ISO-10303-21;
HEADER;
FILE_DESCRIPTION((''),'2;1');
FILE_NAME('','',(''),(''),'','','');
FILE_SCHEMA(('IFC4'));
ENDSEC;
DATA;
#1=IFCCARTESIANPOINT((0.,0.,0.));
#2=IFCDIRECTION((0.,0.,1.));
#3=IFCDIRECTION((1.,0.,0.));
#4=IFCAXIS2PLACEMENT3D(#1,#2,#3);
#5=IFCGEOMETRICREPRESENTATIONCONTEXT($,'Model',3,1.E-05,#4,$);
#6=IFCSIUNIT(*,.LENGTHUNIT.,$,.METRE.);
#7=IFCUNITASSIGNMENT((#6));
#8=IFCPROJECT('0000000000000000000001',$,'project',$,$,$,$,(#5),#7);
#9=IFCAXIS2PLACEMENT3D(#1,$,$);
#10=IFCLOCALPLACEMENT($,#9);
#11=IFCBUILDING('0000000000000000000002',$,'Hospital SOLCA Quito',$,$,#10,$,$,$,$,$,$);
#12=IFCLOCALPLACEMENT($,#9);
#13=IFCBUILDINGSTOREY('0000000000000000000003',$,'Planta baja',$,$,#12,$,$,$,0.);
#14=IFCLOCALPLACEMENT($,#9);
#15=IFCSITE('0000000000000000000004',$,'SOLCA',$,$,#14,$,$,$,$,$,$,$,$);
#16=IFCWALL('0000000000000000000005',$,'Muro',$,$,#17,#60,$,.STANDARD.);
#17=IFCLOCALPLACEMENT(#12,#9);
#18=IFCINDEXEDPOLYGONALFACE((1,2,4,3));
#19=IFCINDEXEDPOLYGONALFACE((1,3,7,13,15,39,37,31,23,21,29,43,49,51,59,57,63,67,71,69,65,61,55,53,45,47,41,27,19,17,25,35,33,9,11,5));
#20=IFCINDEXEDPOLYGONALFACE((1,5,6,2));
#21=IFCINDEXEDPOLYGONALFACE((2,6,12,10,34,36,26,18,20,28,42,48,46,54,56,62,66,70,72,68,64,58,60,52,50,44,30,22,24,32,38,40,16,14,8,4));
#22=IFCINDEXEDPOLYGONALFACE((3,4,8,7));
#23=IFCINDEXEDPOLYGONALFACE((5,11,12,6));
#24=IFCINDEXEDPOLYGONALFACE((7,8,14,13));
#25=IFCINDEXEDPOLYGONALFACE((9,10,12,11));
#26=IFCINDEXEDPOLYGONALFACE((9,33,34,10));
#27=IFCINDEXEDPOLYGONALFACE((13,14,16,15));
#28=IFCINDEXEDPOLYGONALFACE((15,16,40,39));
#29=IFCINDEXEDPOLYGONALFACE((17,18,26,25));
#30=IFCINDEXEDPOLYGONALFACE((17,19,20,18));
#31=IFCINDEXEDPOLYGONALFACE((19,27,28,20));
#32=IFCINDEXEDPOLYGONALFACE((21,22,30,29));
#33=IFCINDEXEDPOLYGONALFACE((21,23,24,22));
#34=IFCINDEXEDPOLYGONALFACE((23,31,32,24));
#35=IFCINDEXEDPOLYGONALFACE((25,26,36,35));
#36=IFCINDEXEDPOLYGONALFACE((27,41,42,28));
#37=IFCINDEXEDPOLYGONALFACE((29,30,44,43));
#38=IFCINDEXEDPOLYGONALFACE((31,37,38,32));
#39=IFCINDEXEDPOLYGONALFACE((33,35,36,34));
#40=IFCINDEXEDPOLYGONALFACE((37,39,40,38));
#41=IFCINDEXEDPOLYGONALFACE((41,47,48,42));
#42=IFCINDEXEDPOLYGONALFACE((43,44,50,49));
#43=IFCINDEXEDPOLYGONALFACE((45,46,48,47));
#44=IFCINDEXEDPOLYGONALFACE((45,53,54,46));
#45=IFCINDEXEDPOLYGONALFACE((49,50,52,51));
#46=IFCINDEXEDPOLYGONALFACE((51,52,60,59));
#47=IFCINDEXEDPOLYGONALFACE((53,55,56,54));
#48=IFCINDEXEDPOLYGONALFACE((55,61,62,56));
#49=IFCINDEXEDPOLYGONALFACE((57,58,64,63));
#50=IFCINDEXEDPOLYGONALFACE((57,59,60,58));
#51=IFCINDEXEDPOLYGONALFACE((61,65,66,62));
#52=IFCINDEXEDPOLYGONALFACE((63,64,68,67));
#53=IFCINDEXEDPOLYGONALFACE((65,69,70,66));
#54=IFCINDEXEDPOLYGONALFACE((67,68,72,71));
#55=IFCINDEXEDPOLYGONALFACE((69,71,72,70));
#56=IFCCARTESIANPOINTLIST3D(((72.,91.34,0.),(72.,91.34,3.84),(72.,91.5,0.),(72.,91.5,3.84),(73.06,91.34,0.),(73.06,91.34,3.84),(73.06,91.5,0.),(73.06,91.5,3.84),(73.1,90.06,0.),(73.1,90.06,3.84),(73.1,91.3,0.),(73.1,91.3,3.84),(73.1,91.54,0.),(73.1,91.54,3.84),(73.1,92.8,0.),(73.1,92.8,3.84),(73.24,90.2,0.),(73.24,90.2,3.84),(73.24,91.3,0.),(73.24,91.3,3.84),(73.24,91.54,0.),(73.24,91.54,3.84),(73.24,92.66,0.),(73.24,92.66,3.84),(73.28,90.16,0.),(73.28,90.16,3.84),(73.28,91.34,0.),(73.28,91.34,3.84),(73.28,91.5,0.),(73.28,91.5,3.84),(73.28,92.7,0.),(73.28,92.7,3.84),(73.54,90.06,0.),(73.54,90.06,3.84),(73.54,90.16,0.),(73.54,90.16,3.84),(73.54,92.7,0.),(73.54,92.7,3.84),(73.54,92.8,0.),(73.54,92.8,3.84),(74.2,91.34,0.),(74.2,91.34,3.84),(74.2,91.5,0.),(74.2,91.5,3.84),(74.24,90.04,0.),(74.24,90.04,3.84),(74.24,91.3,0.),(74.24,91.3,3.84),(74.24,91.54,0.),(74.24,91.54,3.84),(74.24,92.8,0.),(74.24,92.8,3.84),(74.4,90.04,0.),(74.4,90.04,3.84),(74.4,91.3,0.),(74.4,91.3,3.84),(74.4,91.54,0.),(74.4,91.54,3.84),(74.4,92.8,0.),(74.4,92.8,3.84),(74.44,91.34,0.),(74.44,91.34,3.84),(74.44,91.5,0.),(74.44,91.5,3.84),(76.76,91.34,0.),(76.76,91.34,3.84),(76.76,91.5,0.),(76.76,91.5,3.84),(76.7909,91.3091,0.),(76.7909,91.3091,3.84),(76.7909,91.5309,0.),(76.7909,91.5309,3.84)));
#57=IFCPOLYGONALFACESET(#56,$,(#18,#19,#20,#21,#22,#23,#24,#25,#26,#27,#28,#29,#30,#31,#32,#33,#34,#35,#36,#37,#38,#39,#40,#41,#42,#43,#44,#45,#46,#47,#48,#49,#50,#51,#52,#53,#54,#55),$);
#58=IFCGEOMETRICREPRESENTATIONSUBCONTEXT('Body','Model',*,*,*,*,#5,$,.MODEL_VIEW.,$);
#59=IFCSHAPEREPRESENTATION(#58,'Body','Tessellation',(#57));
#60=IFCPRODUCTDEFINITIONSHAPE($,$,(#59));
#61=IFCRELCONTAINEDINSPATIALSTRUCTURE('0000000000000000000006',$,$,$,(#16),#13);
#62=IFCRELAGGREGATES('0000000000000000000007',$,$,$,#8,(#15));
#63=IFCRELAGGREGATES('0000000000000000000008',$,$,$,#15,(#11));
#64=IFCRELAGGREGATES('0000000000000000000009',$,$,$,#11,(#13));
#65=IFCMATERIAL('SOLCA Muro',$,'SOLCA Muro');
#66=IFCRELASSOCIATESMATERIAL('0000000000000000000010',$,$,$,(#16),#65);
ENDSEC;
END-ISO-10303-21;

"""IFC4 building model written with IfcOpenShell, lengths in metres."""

from ifc_helpers import new_model, si_unit, origin, origin_with_axes, place, context, subcontext, project, spatial, polyline, outline, extrude, material, element, save


model = new_model("IFC4")

# Units and contexts
model_context = context("Model", 3, precision=1e-05, world=origin_with_axes())
body_context = subcontext(model_context, "Body", "Model", "MODEL_VIEW")
ifc_project = project(units=[si_unit("LENGTHUNIT", "METRE")], contexts=[model_context])

# Site, building, storey
site_placement = place(None, origin())
site = spatial("IfcSite", under=ifc_project, at=site_placement, Name="SOLCA")
building_placement = place(None, origin())
building = spatial("IfcBuilding", under=site, at=building_placement, Name="Hospital SOLCA Quito")
storey_placement = place(None, origin())
storey = spatial("IfcBuildingStorey", under=building, at=storey_placement, Name="Planta baja", Elevation=0.0)

# Wall
ifc_material = material(Name="SOLCA Muro", Category="SOLCA Muro")
wall_1_placement = place(storey_placement, origin_with_axes())
element("IfcWall", 1, at=wall_1_placement, inside=storey, material=ifc_material, Name="Muro", PredefinedType="STANDARD", context=body_context, shape_type="SweptSolid", body=[
    extrude(outline(polyline([(74.4, 92.8), (74.4, 91.54), (74.44, 91.5), (76.76, 91.5), (76.7909, 91.5309), (76.7909, 91.3091), (76.76, 91.34), (74.44, 91.34), (74.4, 91.3), (74.4, 90.04), (74.24, 90.04), (74.24, 91.3), (74.2, 91.34), (73.28, 91.34), (73.24, 91.3), (73.24, 90.2), (73.28, 90.16), (73.54, 90.16), (73.54, 90.06), (73.1, 90.06), (73.1, 91.3), (73.06, 91.34), (72.0, 91.34), (72.0, 91.5), (73.06, 91.5), (73.1, 91.54), (73.1, 92.8), (73.54, 92.8), (73.54, 92.7), (73.28, 92.7), (73.24, 92.66), (73.24, 91.54), (73.28, 91.5), (74.2, 91.5), (74.24, 91.54), (74.24, 92.8), (74.4, 92.8)])), origin_with_axes(), (0.0, 0.0, 1.0), 3.84),
])

save(model, "model.ifc")
